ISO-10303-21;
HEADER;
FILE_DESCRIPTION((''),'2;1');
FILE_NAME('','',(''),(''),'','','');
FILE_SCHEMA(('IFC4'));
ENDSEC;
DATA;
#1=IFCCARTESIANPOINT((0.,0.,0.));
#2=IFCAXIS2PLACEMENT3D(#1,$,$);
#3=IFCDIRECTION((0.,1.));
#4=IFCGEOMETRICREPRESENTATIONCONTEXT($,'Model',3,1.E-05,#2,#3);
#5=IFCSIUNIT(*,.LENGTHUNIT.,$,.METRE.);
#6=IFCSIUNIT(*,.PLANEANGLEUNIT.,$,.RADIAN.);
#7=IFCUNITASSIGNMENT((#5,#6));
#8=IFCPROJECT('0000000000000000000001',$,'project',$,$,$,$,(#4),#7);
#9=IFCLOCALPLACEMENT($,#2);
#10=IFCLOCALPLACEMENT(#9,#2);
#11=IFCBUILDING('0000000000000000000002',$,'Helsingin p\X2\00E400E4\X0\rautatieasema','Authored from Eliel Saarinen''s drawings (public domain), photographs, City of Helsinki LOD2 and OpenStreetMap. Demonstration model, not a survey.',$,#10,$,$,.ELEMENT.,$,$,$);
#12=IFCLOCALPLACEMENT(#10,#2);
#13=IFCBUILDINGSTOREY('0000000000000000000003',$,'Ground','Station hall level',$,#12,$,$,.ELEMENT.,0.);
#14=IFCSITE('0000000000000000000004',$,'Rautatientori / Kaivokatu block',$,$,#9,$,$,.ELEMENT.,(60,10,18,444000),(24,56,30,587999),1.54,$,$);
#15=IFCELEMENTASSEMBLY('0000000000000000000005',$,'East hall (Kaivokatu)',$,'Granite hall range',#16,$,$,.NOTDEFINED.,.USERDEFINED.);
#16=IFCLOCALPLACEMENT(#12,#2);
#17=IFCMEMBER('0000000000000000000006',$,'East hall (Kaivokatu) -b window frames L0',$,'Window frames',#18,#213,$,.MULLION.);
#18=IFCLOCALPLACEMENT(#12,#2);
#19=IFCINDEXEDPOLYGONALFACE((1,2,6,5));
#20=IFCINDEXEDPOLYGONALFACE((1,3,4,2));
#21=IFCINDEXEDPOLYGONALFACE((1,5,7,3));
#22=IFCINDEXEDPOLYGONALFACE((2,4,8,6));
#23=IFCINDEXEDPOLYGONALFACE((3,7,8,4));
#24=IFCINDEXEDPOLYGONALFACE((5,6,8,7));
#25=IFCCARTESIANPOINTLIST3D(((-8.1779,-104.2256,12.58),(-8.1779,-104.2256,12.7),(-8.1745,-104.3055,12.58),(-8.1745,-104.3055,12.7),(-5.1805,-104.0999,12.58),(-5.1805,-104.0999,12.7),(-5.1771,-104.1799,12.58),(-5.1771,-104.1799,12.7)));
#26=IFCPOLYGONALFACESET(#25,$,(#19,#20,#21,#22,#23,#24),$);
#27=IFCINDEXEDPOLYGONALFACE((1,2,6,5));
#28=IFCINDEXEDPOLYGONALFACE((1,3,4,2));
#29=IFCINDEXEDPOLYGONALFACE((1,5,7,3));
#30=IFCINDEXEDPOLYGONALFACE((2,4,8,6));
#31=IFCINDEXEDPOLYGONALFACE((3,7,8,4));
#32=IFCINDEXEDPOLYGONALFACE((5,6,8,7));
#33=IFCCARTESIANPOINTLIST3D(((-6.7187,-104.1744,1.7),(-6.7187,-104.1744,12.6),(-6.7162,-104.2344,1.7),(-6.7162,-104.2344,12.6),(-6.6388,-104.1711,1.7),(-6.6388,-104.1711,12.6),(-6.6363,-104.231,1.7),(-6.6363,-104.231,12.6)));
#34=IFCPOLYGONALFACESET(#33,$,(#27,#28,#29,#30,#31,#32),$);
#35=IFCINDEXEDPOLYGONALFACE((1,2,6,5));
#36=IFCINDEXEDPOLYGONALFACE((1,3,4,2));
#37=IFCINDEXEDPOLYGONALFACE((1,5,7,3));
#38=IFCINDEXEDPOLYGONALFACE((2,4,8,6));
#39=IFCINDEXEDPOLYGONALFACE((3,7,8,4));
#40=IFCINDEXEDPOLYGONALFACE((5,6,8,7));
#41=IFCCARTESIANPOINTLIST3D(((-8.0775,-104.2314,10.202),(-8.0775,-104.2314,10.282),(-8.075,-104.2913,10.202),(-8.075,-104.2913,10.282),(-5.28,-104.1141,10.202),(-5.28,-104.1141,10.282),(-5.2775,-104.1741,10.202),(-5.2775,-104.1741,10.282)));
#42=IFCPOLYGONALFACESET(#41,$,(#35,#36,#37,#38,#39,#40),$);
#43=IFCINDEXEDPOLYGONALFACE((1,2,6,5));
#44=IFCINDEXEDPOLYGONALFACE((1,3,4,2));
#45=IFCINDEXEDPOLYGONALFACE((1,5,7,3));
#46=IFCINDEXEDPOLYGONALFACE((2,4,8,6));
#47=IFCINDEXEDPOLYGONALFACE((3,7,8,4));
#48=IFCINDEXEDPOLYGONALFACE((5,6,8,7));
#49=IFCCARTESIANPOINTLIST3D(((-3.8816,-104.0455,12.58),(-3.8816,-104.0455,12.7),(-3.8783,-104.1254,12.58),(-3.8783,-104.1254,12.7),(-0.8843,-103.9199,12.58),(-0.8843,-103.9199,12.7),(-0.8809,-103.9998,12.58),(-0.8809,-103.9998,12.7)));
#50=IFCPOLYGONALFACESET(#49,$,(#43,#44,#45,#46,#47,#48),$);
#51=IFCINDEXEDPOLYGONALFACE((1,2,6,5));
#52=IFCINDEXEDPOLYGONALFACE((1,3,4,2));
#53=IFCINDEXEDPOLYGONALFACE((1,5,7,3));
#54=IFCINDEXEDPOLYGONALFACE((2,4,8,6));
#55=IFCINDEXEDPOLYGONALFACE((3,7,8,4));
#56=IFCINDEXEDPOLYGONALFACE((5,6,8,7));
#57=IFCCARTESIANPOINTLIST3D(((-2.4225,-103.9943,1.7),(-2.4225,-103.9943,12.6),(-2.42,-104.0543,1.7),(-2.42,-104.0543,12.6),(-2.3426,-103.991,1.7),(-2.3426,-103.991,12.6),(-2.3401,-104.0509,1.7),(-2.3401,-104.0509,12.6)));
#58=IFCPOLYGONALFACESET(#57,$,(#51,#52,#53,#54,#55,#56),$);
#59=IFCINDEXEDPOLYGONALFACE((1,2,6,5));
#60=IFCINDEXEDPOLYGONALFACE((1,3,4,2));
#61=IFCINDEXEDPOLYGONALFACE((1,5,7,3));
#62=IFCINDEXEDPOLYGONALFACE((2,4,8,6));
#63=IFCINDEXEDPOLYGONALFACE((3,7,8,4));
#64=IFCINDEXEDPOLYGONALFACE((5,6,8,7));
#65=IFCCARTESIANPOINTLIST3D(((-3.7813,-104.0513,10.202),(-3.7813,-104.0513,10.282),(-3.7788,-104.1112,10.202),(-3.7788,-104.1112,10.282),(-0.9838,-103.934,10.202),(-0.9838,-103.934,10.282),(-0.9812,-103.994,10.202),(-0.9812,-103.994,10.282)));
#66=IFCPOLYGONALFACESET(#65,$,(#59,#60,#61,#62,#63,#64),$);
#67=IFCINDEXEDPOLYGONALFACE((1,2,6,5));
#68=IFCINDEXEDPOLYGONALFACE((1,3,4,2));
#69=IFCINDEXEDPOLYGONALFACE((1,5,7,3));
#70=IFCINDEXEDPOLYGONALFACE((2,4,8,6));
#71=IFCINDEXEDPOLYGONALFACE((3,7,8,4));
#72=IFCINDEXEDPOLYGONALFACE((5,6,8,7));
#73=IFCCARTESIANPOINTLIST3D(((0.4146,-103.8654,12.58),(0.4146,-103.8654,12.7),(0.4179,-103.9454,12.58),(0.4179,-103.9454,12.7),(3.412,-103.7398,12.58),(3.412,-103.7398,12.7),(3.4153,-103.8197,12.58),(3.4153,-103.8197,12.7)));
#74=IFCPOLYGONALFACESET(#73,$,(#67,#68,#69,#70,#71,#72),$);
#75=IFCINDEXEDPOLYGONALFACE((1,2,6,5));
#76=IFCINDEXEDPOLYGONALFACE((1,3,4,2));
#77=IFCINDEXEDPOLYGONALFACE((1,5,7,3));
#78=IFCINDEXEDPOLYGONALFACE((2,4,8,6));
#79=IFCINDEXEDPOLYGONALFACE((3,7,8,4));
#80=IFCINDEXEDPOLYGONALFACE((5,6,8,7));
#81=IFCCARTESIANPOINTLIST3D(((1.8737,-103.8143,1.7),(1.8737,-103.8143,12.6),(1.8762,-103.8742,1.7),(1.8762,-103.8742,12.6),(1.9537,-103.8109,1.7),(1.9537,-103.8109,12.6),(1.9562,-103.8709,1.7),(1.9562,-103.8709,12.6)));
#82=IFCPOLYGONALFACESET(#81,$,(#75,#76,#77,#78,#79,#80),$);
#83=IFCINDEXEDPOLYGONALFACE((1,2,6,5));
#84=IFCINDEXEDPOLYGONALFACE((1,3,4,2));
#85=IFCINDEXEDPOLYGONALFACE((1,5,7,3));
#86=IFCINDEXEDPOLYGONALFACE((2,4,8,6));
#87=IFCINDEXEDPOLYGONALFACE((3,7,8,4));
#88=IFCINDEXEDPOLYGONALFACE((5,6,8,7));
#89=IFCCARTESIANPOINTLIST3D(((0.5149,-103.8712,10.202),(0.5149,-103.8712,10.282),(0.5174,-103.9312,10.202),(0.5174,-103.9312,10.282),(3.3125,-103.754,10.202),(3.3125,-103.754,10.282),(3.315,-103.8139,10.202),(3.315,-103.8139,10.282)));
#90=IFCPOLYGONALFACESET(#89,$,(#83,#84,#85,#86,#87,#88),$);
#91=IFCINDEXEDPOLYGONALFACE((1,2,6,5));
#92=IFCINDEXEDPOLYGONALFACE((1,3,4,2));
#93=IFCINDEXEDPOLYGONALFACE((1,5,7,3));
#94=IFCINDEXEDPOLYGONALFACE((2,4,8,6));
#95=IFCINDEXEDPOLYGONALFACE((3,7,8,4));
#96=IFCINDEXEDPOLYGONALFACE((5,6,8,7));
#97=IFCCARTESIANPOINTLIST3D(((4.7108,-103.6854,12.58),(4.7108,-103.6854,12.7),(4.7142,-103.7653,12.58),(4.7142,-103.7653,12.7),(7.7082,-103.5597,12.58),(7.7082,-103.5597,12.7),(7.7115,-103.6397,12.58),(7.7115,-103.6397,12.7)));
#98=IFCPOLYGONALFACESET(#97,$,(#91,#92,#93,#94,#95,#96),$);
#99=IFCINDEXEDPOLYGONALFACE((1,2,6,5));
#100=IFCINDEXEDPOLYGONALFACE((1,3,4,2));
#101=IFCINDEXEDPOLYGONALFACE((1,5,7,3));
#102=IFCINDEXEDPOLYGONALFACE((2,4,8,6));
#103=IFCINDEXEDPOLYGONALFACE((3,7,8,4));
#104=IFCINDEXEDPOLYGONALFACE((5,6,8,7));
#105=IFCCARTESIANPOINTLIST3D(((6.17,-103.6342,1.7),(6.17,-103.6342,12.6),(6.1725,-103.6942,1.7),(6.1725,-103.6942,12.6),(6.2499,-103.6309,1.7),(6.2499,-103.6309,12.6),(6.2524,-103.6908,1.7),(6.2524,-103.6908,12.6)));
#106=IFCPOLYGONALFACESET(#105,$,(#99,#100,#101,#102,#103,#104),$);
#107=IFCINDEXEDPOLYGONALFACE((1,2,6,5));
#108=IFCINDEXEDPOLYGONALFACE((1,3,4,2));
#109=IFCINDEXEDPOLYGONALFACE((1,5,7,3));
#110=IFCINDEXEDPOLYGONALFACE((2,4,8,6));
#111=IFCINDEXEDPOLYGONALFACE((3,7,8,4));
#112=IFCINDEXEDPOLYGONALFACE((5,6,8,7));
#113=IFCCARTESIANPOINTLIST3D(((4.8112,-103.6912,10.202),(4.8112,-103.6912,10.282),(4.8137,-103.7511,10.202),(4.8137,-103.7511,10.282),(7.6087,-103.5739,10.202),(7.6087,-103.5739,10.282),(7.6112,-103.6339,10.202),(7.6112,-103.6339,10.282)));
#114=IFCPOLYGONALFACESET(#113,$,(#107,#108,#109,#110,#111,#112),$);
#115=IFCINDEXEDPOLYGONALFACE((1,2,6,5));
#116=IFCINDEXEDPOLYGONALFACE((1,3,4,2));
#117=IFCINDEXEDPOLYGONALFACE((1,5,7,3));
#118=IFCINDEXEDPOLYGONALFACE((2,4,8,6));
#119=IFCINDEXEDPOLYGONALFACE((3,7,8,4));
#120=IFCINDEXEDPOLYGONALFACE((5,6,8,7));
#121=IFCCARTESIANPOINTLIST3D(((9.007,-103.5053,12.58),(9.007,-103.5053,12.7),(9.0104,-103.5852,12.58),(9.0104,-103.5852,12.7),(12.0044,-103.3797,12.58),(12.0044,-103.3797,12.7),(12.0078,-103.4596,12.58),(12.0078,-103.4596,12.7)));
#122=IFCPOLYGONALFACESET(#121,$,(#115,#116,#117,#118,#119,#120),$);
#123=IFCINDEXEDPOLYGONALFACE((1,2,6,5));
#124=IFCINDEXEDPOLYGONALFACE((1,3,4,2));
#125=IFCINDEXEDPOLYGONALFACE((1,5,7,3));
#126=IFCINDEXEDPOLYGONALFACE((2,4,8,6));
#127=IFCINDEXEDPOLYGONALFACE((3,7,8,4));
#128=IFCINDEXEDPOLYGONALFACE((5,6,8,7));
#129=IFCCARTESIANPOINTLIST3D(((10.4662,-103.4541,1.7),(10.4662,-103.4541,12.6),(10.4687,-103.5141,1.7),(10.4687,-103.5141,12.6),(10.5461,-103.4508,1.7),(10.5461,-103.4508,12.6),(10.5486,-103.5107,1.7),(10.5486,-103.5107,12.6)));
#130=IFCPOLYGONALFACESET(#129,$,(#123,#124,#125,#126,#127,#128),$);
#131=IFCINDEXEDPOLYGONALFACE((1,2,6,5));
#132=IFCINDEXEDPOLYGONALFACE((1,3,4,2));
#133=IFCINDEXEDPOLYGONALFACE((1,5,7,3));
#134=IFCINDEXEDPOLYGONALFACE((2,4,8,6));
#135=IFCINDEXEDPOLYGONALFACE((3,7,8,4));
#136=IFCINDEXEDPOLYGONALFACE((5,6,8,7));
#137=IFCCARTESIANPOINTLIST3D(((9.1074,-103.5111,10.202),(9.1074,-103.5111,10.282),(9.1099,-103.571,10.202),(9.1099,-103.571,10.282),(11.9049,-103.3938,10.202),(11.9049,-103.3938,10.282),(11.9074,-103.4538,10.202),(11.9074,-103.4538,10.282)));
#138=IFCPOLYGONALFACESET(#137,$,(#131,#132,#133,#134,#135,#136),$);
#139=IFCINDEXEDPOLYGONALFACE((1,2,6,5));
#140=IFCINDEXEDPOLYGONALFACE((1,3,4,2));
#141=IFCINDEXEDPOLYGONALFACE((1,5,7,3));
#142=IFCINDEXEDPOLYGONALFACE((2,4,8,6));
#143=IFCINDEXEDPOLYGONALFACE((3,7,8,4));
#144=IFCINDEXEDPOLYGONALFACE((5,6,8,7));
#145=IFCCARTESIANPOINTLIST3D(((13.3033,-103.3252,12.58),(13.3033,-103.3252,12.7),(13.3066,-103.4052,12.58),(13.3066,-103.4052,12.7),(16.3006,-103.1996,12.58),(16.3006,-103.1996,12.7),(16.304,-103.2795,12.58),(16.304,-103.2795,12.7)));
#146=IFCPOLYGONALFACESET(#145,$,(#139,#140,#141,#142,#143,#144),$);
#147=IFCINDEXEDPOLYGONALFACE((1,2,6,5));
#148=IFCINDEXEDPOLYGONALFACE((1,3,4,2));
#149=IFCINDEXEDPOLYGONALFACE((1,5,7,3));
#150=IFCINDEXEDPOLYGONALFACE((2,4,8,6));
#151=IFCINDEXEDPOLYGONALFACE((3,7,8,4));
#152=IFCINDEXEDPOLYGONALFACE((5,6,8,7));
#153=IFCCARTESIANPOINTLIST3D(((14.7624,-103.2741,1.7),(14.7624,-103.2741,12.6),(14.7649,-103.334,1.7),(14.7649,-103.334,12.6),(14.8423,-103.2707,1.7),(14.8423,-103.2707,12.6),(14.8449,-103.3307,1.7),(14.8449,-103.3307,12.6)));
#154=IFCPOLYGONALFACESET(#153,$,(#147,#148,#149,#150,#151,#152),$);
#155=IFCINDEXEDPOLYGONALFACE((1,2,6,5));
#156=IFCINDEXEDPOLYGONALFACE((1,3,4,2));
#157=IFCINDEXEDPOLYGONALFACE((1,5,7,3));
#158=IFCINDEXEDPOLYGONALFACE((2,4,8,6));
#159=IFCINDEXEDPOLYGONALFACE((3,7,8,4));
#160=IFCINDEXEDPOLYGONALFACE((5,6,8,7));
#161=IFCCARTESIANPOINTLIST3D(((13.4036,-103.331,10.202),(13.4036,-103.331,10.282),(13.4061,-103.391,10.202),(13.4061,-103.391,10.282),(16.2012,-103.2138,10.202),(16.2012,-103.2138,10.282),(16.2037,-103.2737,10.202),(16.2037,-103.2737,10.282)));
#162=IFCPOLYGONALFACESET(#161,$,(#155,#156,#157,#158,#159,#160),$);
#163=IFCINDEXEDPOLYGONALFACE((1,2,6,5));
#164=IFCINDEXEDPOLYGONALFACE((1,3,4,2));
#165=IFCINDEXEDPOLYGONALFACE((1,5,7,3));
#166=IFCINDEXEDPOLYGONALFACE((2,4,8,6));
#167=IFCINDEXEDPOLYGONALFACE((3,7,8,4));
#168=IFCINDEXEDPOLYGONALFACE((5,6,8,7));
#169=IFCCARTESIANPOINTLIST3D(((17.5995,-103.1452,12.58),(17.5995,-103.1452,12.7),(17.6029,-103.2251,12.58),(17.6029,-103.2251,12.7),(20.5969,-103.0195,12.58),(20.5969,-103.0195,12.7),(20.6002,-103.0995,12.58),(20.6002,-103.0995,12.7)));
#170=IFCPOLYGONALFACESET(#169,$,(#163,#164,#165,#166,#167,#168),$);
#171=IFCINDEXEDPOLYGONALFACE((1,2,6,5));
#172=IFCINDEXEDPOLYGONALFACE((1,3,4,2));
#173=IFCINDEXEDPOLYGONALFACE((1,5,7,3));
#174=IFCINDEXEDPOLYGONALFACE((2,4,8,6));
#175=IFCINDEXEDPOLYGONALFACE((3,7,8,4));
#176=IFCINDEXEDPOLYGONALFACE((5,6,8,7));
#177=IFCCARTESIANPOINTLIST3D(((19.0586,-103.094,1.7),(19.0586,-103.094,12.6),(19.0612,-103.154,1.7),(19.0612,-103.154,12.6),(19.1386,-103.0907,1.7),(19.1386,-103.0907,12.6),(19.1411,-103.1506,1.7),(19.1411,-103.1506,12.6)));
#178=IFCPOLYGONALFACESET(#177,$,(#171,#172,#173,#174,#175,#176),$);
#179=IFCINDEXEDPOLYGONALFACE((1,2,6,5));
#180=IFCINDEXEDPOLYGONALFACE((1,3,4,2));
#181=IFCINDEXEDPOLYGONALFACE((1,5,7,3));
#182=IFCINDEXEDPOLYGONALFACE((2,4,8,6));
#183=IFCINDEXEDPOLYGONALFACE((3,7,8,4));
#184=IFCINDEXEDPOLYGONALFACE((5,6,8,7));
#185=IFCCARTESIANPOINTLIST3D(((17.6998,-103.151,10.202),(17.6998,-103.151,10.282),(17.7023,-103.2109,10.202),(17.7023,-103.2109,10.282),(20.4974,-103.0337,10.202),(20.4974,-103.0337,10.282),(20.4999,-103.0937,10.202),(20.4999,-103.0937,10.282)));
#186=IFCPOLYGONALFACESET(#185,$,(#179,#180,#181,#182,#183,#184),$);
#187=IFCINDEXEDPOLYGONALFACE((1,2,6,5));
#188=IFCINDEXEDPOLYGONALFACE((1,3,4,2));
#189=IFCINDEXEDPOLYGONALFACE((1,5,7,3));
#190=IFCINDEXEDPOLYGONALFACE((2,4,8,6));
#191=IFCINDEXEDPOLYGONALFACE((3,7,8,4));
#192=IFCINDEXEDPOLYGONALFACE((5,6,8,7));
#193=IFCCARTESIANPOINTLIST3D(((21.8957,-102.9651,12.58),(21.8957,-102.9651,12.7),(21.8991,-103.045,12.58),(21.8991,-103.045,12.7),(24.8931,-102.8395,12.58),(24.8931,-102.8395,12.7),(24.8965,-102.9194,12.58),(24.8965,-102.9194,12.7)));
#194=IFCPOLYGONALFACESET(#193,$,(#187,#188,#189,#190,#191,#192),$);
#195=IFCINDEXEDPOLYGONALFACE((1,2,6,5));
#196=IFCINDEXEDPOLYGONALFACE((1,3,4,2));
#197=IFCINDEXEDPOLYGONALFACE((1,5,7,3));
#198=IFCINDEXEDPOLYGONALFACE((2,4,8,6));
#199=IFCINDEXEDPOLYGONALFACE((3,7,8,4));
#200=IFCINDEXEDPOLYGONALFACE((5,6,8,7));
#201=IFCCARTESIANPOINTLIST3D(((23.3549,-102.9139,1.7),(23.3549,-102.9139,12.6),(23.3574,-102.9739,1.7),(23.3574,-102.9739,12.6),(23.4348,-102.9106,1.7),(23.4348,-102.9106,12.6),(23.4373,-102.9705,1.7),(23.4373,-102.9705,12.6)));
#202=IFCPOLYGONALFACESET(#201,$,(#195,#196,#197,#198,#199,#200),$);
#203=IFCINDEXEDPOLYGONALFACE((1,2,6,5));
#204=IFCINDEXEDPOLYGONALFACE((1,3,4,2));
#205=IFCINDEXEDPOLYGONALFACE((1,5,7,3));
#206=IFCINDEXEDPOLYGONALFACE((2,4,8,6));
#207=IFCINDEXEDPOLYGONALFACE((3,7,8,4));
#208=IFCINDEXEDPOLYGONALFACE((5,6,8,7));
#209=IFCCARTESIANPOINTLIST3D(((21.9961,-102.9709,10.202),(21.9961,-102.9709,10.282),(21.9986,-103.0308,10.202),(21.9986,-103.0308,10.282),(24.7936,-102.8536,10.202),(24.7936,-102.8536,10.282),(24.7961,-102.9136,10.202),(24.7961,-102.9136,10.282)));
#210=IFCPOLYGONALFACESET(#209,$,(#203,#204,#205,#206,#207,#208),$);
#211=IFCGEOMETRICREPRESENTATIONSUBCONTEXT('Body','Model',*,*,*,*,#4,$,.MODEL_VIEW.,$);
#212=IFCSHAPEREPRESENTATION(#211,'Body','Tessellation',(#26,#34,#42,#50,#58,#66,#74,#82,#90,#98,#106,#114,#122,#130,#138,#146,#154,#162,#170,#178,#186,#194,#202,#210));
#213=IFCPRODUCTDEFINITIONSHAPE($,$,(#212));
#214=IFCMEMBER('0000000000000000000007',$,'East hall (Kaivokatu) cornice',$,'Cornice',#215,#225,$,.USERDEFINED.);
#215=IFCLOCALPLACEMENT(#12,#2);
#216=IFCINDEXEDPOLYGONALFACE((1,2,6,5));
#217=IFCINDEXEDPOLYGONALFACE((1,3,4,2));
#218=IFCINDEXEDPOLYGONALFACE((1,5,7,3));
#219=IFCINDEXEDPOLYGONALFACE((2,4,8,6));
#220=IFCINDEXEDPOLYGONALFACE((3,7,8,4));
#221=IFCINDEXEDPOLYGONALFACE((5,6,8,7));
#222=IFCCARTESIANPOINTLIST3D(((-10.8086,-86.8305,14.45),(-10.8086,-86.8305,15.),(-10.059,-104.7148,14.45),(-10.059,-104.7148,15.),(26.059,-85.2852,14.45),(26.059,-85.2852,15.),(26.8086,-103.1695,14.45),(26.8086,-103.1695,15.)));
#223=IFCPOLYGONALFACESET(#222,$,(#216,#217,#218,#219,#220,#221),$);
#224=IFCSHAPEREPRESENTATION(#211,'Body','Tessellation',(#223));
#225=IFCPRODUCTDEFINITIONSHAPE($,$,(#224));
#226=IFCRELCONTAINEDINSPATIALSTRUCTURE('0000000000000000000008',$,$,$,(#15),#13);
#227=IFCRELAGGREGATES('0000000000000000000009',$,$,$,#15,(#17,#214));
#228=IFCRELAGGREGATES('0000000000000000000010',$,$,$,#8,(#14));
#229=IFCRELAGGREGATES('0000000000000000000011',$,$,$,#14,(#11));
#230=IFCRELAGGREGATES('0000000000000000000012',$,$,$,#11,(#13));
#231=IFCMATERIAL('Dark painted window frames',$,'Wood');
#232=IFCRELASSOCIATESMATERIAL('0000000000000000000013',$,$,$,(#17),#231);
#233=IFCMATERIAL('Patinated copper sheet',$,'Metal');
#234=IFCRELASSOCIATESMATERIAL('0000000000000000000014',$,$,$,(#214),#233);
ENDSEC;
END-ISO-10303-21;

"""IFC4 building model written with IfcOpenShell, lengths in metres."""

from ifc_helpers import new_model, si_unit, direction, frame, frame_2d, origin, place, context, subcontext, project, spatial, rectangle, extrude, material, element, aggregate, save


model = new_model("IFC4")

# Units and contexts
model_context = context("Model", 3, precision=1e-05, world=origin(), true_north=direction((0.0, 1.0)))
body_context = subcontext(model_context, "Body", "Model", "MODEL_VIEW")
ifc_project = project(units=[si_unit("LENGTHUNIT", "METRE"), si_unit("PLANEANGLEUNIT", "RADIAN")], contexts=[model_context])

# Site, building, storey
site_placement = place(None, origin())
site = spatial("IfcSite", under=ifc_project, at=site_placement, Name="Rautatientori / Kaivokatu block", CompositionType="ELEMENT", RefLatitude=(60, 10, 18, 444000), RefLongitude=(24, 56, 30, 587999), RefElevation=1.54)
building_placement = place(site_placement, origin())
building = spatial("IfcBuilding", under=site, at=building_placement, Name="Helsingin päärautatieasema", Description="Authored from Eliel Saarinen's drawings (public domain), photographs, City of Helsinki LOD2 and OpenStreetMap. Demonstration model, not a survey.", CompositionType="ELEMENT")
storey_placement = place(building_placement, origin())
storey = spatial("IfcBuildingStorey", under=building, at=storey_placement, Name="Ground", Description="Station hall level", CompositionType="ELEMENT", Elevation=0.0)

# Element assembly
assembly_1_placement = place(building_placement, origin())
assembly_1 = element("IfcElementAssembly", 1, at=assembly_1_placement, inside=storey, Name="East hall (Kaivokatu)", ObjectType="Granite hall range", AssemblyPlace="NOTDEFINED", PredefinedType="USERDEFINED")

# Members
ifc_material_1 = material(Name="Dark painted window frames", Category="Wood")
ifc_material_2 = material(Name="Patinated copper sheet", Category="Metal")
member_1_placement = place(building_placement, origin())
member_1 = element("IfcMember", 2, at=member_1_placement, material=ifc_material_1, Name="East hall (Kaivokatu) -b window frames L0", ObjectType="Window frames", PredefinedType="MULLION", context=body_context, shape_type="SweptSolid", body=[
    extrude(rectangle(XDim=3.0, YDim=0.08, at=frame_2d((0.0, 0.0), x_axis=(0.999123, 0.041876))), frame((-6.6775, -104.2027, 12.58)), (0.0, 0.0, 1.0), 0.12),
    extrude(rectangle(XDim=0.08, YDim=0.06, at=frame_2d((0.0, 0.0), x_axis=(0.999123, 0.041876))), frame((-6.6775, -104.2027, 1.7)), (0.0, 0.0, 1.0), 10.9),
    extrude(rectangle(XDim=2.8, YDim=0.06, at=frame_2d((0.0, 0.0), x_axis=(0.999123, 0.041876))), frame((-6.6775, -104.2027, 10.202)), (0.0, 0.0, 1.0), 0.08),
    extrude(rectangle(XDim=3.0, YDim=0.08, at=frame_2d((0.0, 0.0), x_axis=(0.999123, 0.041876))), frame((-2.3813, -104.0226, 12.58)), (0.0, 0.0, 1.0), 0.12),
    extrude(rectangle(XDim=0.08, YDim=0.06, at=frame_2d((0.0, 0.0), x_axis=(0.999123, 0.041876))), frame((-2.3813, -104.0226, 1.7)), (0.0, 0.0, 1.0), 10.9),
    extrude(rectangle(XDim=2.8, YDim=0.06, at=frame_2d((0.0, 0.0), x_axis=(0.999123, 0.041876))), frame((-2.3813, -104.0226, 10.202)), (0.0, 0.0, 1.0), 0.08),
    extrude(rectangle(XDim=3.0, YDim=0.08, at=frame_2d((0.0, 0.0), x_axis=(0.999123, 0.041876))), frame((1.915, -103.8426, 12.58)), (0.0, 0.0, 1.0), 0.12),
    extrude(rectangle(XDim=0.08, YDim=0.06, at=frame_2d((0.0, 0.0), x_axis=(0.999123, 0.041876))), frame((1.915, -103.8426, 1.7)), (0.0, 0.0, 1.0), 10.9),
    extrude(rectangle(XDim=2.8, YDim=0.06, at=frame_2d((0.0, 0.0), x_axis=(0.999123, 0.041876))), frame((1.915, -103.8426, 10.202)), (0.0, 0.0, 1.0), 0.08),
    extrude(rectangle(XDim=3.0, YDim=0.08, at=frame_2d((0.0, 0.0), x_axis=(0.999123, 0.041876))), frame((6.2112, -103.6625, 12.58)), (0.0, 0.0, 1.0), 0.12),
    extrude(rectangle(XDim=0.08, YDim=0.06, at=frame_2d((0.0, 0.0), x_axis=(0.999123, 0.041876))), frame((6.2112, -103.6625, 1.7)), (0.0, 0.0, 1.0), 10.9),
    extrude(rectangle(XDim=2.8, YDim=0.06, at=frame_2d((0.0, 0.0), x_axis=(0.999123, 0.041876))), frame((6.2112, -103.6625, 10.202)), (0.0, 0.0, 1.0), 0.08),
    extrude(rectangle(XDim=3.0, YDim=0.08, at=frame_2d((0.0, 0.0), x_axis=(0.999123, 0.041876))), frame((10.5074, -103.4824, 12.58)), (0.0, 0.0, 1.0), 0.12),
    extrude(rectangle(XDim=0.08, YDim=0.06, at=frame_2d((0.0, 0.0), x_axis=(0.999123, 0.041876))), frame((10.5074, -103.4824, 1.7)), (0.0, 0.0, 1.0), 10.9),
    extrude(rectangle(XDim=2.8, YDim=0.06, at=frame_2d((0.0, 0.0), x_axis=(0.999123, 0.041876))), frame((10.5074, -103.4824, 10.202)), (0.0, 0.0, 1.0), 0.08),
    extrude(rectangle(XDim=3.0, YDim=0.08, at=frame_2d((0.0, 0.0), x_axis=(0.999123, 0.041876))), frame((14.8036, -103.3024, 12.58)), (0.0, 0.0, 1.0), 0.12),
    extrude(rectangle(XDim=0.08, YDim=0.06, at=frame_2d((0.0, 0.0), x_axis=(0.999123, 0.041876))), frame((14.8036, -103.3024, 1.7)), (0.0, 0.0, 1.0), 10.9),
    extrude(rectangle(XDim=2.8, YDim=0.06, at=frame_2d((0.0, 0.0), x_axis=(0.999123, 0.041876))), frame((14.8036, -103.3024, 10.202)), (0.0, 0.0, 1.0), 0.08),
    extrude(rectangle(XDim=3.0, YDim=0.08, at=frame_2d((0.0, 0.0), x_axis=(0.999123, 0.041876))), frame((19.0999, -103.1223, 12.58)), (0.0, 0.0, 1.0), 0.12),
    extrude(rectangle(XDim=0.08, YDim=0.06, at=frame_2d((0.0, 0.0), x_axis=(0.999123, 0.041876))), frame((19.0999, -103.1223, 1.7)), (0.0, 0.0, 1.0), 10.9),
    extrude(rectangle(XDim=2.8, YDim=0.06, at=frame_2d((0.0, 0.0), x_axis=(0.999123, 0.041876))), frame((19.0999, -103.1223, 10.202)), (0.0, 0.0, 1.0), 0.08),
    extrude(rectangle(XDim=3.0, YDim=0.08, at=frame_2d((0.0, 0.0), x_axis=(0.999123, 0.041876))), frame((23.3961, -102.9422, 12.58)), (0.0, 0.0, 1.0), 0.12),
    extrude(rectangle(XDim=0.08, YDim=0.06, at=frame_2d((0.0, 0.0), x_axis=(0.999123, 0.041876))), frame((23.3961, -102.9422, 1.7)), (0.0, 0.0, 1.0), 10.9),
    extrude(rectangle(XDim=2.8, YDim=0.06, at=frame_2d((0.0, 0.0), x_axis=(0.999123, 0.041876))), frame((23.3961, -102.9422, 10.202)), (0.0, 0.0, 1.0), 0.08),
])
member_2_placement = place(building_placement, origin())
member_2 = element("IfcMember", 3, at=member_2_placement, material=ifc_material_2, Name="East hall (Kaivokatu) cornice", ObjectType="Cornice", PredefinedType="USERDEFINED", context=body_context, shape_type="SweptSolid", body=[
    extrude(rectangle(XDim=36.9, YDim=17.9, at=frame_2d((0.0, 0.0), x_axis=(0.999123, 0.041876))), frame((8.0, -95.0, 14.45)), (0.0, 0.0, 1.0), 0.55),
])

aggregate(assembly_1, [member_1, member_2])

save(model, "model.ifc")
